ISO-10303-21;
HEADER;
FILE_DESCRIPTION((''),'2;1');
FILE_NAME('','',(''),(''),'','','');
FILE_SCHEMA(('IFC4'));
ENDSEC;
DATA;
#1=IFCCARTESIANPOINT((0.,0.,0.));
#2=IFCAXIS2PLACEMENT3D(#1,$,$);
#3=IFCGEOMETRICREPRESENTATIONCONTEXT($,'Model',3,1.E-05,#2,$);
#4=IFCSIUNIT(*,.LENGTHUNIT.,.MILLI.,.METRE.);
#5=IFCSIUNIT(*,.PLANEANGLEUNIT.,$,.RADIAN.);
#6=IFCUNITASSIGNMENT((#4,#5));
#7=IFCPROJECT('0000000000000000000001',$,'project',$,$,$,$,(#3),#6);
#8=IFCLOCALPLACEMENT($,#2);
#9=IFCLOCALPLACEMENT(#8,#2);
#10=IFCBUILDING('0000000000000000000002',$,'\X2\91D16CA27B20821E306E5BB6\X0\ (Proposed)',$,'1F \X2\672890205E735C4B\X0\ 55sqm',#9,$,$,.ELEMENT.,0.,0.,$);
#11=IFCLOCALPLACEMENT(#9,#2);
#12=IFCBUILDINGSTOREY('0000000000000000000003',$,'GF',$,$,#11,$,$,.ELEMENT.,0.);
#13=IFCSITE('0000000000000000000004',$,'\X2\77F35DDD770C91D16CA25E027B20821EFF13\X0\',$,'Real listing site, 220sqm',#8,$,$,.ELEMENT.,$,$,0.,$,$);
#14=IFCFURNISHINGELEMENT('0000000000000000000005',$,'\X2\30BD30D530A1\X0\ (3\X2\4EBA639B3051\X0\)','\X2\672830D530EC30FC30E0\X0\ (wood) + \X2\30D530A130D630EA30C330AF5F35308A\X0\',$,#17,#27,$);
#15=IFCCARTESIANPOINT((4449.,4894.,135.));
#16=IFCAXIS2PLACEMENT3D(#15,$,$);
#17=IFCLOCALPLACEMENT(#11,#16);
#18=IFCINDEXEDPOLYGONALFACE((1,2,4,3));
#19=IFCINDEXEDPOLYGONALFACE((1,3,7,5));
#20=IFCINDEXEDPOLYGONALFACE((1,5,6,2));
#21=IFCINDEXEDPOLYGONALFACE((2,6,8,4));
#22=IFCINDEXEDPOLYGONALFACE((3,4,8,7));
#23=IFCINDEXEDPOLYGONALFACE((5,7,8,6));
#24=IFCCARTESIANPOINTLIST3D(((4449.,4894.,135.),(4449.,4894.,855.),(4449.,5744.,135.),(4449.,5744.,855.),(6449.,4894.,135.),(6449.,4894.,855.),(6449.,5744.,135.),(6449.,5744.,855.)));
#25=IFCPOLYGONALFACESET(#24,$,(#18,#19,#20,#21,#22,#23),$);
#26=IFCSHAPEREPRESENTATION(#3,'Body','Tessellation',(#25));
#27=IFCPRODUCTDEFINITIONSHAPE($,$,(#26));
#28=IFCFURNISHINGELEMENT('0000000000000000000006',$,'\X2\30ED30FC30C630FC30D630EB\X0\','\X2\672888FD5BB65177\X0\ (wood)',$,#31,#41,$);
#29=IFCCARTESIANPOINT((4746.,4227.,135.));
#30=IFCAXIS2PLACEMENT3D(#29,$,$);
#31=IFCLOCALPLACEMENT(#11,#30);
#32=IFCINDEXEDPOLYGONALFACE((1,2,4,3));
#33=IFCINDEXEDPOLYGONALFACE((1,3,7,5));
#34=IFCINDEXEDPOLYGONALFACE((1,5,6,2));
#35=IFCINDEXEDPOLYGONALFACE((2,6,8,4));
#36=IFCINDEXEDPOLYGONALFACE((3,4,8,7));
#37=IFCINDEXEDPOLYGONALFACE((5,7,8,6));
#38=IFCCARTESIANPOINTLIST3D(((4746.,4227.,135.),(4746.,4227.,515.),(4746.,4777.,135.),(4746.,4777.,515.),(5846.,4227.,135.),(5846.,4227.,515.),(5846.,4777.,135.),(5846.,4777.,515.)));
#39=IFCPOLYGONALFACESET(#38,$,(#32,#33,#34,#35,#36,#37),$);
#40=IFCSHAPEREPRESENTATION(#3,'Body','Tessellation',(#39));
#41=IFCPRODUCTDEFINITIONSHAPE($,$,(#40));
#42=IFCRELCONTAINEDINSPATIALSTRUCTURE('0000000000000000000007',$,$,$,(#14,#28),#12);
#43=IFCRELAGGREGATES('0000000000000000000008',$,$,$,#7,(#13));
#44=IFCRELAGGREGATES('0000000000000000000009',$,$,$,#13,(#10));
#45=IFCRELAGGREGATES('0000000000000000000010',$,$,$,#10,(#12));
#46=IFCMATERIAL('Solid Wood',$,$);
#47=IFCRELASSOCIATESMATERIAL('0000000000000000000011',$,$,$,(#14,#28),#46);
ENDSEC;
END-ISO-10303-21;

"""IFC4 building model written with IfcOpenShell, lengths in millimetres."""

from ifc_helpers import new_model, si_unit, frame, frame_2d, origin, place, context, project, spatial, rectangle, extrude, material, element, save


model = new_model("IFC4")

# Units and contexts
model_context = context("Model", 3, precision=1e-05, world=origin())
ifc_project = project(units=[si_unit("LENGTHUNIT", "METRE", prefix="MILLI"), si_unit("PLANEANGLEUNIT", "RADIAN")], contexts=[model_context])

# Site, building, storey
site_placement = place(None, origin())
site = spatial("IfcSite", under=ifc_project, at=site_placement, Name="石川県金沢市笠舞３", ObjectType="Real listing site, 220sqm", CompositionType="ELEMENT", RefElevation=0.0)
building_placement = place(site_placement, origin())
building = spatial("IfcBuilding", under=site, at=building_placement, Name="金沢笠舞の家 (Proposed)", ObjectType="1F 木造平屋 55sqm", CompositionType="ELEMENT", ElevationOfRefHeight=0.0, ElevationOfTerrain=0.0)
storey_placement = place(building_placement, origin())
storey = spatial("IfcBuildingStorey", under=building, at=storey_placement, Name="GF", CompositionType="ELEMENT", Elevation=0.0)

# Shared definitions
ifc_material_1 = material(Name="Solid Wood")

# Furnishing elements
furnishing_1_placement = place(storey_placement, frame((4449.0, 4894.0, 135.0)))
element("IfcFurnishingElement", 1, at=furnishing_1_placement, inside=storey, material=ifc_material_1, Name="ソファ (3人掛け)", Description="木フレーム (wood) + ファブリック張り", context=model_context, shape_type="SweptSolid", body=[
    extrude(rectangle(XDim=2000.0, YDim=850.0, at=frame_2d((1000.0, 425.0))), frame((4449.0, 4894.0, 135.0)), (0.0, 0.0, 1.0), 720.0),
])
furnishing_2_placement = place(storey_placement, frame((4746.0, 4227.0, 135.0)))
element("IfcFurnishingElement", 2, at=furnishing_2_placement, inside=storey, material=ifc_material_1, Name="ローテーブル", Description="木製家具 (wood)", context=model_context, shape_type="SweptSolid", body=[
    extrude(rectangle(XDim=1100.0, YDim=550.0, at=frame_2d((550.0, 275.0))), frame((4746.0, 4227.0, 135.0)), (0.0, 0.0, 1.0), 380.0),
])

save(model, "model.ifc")
